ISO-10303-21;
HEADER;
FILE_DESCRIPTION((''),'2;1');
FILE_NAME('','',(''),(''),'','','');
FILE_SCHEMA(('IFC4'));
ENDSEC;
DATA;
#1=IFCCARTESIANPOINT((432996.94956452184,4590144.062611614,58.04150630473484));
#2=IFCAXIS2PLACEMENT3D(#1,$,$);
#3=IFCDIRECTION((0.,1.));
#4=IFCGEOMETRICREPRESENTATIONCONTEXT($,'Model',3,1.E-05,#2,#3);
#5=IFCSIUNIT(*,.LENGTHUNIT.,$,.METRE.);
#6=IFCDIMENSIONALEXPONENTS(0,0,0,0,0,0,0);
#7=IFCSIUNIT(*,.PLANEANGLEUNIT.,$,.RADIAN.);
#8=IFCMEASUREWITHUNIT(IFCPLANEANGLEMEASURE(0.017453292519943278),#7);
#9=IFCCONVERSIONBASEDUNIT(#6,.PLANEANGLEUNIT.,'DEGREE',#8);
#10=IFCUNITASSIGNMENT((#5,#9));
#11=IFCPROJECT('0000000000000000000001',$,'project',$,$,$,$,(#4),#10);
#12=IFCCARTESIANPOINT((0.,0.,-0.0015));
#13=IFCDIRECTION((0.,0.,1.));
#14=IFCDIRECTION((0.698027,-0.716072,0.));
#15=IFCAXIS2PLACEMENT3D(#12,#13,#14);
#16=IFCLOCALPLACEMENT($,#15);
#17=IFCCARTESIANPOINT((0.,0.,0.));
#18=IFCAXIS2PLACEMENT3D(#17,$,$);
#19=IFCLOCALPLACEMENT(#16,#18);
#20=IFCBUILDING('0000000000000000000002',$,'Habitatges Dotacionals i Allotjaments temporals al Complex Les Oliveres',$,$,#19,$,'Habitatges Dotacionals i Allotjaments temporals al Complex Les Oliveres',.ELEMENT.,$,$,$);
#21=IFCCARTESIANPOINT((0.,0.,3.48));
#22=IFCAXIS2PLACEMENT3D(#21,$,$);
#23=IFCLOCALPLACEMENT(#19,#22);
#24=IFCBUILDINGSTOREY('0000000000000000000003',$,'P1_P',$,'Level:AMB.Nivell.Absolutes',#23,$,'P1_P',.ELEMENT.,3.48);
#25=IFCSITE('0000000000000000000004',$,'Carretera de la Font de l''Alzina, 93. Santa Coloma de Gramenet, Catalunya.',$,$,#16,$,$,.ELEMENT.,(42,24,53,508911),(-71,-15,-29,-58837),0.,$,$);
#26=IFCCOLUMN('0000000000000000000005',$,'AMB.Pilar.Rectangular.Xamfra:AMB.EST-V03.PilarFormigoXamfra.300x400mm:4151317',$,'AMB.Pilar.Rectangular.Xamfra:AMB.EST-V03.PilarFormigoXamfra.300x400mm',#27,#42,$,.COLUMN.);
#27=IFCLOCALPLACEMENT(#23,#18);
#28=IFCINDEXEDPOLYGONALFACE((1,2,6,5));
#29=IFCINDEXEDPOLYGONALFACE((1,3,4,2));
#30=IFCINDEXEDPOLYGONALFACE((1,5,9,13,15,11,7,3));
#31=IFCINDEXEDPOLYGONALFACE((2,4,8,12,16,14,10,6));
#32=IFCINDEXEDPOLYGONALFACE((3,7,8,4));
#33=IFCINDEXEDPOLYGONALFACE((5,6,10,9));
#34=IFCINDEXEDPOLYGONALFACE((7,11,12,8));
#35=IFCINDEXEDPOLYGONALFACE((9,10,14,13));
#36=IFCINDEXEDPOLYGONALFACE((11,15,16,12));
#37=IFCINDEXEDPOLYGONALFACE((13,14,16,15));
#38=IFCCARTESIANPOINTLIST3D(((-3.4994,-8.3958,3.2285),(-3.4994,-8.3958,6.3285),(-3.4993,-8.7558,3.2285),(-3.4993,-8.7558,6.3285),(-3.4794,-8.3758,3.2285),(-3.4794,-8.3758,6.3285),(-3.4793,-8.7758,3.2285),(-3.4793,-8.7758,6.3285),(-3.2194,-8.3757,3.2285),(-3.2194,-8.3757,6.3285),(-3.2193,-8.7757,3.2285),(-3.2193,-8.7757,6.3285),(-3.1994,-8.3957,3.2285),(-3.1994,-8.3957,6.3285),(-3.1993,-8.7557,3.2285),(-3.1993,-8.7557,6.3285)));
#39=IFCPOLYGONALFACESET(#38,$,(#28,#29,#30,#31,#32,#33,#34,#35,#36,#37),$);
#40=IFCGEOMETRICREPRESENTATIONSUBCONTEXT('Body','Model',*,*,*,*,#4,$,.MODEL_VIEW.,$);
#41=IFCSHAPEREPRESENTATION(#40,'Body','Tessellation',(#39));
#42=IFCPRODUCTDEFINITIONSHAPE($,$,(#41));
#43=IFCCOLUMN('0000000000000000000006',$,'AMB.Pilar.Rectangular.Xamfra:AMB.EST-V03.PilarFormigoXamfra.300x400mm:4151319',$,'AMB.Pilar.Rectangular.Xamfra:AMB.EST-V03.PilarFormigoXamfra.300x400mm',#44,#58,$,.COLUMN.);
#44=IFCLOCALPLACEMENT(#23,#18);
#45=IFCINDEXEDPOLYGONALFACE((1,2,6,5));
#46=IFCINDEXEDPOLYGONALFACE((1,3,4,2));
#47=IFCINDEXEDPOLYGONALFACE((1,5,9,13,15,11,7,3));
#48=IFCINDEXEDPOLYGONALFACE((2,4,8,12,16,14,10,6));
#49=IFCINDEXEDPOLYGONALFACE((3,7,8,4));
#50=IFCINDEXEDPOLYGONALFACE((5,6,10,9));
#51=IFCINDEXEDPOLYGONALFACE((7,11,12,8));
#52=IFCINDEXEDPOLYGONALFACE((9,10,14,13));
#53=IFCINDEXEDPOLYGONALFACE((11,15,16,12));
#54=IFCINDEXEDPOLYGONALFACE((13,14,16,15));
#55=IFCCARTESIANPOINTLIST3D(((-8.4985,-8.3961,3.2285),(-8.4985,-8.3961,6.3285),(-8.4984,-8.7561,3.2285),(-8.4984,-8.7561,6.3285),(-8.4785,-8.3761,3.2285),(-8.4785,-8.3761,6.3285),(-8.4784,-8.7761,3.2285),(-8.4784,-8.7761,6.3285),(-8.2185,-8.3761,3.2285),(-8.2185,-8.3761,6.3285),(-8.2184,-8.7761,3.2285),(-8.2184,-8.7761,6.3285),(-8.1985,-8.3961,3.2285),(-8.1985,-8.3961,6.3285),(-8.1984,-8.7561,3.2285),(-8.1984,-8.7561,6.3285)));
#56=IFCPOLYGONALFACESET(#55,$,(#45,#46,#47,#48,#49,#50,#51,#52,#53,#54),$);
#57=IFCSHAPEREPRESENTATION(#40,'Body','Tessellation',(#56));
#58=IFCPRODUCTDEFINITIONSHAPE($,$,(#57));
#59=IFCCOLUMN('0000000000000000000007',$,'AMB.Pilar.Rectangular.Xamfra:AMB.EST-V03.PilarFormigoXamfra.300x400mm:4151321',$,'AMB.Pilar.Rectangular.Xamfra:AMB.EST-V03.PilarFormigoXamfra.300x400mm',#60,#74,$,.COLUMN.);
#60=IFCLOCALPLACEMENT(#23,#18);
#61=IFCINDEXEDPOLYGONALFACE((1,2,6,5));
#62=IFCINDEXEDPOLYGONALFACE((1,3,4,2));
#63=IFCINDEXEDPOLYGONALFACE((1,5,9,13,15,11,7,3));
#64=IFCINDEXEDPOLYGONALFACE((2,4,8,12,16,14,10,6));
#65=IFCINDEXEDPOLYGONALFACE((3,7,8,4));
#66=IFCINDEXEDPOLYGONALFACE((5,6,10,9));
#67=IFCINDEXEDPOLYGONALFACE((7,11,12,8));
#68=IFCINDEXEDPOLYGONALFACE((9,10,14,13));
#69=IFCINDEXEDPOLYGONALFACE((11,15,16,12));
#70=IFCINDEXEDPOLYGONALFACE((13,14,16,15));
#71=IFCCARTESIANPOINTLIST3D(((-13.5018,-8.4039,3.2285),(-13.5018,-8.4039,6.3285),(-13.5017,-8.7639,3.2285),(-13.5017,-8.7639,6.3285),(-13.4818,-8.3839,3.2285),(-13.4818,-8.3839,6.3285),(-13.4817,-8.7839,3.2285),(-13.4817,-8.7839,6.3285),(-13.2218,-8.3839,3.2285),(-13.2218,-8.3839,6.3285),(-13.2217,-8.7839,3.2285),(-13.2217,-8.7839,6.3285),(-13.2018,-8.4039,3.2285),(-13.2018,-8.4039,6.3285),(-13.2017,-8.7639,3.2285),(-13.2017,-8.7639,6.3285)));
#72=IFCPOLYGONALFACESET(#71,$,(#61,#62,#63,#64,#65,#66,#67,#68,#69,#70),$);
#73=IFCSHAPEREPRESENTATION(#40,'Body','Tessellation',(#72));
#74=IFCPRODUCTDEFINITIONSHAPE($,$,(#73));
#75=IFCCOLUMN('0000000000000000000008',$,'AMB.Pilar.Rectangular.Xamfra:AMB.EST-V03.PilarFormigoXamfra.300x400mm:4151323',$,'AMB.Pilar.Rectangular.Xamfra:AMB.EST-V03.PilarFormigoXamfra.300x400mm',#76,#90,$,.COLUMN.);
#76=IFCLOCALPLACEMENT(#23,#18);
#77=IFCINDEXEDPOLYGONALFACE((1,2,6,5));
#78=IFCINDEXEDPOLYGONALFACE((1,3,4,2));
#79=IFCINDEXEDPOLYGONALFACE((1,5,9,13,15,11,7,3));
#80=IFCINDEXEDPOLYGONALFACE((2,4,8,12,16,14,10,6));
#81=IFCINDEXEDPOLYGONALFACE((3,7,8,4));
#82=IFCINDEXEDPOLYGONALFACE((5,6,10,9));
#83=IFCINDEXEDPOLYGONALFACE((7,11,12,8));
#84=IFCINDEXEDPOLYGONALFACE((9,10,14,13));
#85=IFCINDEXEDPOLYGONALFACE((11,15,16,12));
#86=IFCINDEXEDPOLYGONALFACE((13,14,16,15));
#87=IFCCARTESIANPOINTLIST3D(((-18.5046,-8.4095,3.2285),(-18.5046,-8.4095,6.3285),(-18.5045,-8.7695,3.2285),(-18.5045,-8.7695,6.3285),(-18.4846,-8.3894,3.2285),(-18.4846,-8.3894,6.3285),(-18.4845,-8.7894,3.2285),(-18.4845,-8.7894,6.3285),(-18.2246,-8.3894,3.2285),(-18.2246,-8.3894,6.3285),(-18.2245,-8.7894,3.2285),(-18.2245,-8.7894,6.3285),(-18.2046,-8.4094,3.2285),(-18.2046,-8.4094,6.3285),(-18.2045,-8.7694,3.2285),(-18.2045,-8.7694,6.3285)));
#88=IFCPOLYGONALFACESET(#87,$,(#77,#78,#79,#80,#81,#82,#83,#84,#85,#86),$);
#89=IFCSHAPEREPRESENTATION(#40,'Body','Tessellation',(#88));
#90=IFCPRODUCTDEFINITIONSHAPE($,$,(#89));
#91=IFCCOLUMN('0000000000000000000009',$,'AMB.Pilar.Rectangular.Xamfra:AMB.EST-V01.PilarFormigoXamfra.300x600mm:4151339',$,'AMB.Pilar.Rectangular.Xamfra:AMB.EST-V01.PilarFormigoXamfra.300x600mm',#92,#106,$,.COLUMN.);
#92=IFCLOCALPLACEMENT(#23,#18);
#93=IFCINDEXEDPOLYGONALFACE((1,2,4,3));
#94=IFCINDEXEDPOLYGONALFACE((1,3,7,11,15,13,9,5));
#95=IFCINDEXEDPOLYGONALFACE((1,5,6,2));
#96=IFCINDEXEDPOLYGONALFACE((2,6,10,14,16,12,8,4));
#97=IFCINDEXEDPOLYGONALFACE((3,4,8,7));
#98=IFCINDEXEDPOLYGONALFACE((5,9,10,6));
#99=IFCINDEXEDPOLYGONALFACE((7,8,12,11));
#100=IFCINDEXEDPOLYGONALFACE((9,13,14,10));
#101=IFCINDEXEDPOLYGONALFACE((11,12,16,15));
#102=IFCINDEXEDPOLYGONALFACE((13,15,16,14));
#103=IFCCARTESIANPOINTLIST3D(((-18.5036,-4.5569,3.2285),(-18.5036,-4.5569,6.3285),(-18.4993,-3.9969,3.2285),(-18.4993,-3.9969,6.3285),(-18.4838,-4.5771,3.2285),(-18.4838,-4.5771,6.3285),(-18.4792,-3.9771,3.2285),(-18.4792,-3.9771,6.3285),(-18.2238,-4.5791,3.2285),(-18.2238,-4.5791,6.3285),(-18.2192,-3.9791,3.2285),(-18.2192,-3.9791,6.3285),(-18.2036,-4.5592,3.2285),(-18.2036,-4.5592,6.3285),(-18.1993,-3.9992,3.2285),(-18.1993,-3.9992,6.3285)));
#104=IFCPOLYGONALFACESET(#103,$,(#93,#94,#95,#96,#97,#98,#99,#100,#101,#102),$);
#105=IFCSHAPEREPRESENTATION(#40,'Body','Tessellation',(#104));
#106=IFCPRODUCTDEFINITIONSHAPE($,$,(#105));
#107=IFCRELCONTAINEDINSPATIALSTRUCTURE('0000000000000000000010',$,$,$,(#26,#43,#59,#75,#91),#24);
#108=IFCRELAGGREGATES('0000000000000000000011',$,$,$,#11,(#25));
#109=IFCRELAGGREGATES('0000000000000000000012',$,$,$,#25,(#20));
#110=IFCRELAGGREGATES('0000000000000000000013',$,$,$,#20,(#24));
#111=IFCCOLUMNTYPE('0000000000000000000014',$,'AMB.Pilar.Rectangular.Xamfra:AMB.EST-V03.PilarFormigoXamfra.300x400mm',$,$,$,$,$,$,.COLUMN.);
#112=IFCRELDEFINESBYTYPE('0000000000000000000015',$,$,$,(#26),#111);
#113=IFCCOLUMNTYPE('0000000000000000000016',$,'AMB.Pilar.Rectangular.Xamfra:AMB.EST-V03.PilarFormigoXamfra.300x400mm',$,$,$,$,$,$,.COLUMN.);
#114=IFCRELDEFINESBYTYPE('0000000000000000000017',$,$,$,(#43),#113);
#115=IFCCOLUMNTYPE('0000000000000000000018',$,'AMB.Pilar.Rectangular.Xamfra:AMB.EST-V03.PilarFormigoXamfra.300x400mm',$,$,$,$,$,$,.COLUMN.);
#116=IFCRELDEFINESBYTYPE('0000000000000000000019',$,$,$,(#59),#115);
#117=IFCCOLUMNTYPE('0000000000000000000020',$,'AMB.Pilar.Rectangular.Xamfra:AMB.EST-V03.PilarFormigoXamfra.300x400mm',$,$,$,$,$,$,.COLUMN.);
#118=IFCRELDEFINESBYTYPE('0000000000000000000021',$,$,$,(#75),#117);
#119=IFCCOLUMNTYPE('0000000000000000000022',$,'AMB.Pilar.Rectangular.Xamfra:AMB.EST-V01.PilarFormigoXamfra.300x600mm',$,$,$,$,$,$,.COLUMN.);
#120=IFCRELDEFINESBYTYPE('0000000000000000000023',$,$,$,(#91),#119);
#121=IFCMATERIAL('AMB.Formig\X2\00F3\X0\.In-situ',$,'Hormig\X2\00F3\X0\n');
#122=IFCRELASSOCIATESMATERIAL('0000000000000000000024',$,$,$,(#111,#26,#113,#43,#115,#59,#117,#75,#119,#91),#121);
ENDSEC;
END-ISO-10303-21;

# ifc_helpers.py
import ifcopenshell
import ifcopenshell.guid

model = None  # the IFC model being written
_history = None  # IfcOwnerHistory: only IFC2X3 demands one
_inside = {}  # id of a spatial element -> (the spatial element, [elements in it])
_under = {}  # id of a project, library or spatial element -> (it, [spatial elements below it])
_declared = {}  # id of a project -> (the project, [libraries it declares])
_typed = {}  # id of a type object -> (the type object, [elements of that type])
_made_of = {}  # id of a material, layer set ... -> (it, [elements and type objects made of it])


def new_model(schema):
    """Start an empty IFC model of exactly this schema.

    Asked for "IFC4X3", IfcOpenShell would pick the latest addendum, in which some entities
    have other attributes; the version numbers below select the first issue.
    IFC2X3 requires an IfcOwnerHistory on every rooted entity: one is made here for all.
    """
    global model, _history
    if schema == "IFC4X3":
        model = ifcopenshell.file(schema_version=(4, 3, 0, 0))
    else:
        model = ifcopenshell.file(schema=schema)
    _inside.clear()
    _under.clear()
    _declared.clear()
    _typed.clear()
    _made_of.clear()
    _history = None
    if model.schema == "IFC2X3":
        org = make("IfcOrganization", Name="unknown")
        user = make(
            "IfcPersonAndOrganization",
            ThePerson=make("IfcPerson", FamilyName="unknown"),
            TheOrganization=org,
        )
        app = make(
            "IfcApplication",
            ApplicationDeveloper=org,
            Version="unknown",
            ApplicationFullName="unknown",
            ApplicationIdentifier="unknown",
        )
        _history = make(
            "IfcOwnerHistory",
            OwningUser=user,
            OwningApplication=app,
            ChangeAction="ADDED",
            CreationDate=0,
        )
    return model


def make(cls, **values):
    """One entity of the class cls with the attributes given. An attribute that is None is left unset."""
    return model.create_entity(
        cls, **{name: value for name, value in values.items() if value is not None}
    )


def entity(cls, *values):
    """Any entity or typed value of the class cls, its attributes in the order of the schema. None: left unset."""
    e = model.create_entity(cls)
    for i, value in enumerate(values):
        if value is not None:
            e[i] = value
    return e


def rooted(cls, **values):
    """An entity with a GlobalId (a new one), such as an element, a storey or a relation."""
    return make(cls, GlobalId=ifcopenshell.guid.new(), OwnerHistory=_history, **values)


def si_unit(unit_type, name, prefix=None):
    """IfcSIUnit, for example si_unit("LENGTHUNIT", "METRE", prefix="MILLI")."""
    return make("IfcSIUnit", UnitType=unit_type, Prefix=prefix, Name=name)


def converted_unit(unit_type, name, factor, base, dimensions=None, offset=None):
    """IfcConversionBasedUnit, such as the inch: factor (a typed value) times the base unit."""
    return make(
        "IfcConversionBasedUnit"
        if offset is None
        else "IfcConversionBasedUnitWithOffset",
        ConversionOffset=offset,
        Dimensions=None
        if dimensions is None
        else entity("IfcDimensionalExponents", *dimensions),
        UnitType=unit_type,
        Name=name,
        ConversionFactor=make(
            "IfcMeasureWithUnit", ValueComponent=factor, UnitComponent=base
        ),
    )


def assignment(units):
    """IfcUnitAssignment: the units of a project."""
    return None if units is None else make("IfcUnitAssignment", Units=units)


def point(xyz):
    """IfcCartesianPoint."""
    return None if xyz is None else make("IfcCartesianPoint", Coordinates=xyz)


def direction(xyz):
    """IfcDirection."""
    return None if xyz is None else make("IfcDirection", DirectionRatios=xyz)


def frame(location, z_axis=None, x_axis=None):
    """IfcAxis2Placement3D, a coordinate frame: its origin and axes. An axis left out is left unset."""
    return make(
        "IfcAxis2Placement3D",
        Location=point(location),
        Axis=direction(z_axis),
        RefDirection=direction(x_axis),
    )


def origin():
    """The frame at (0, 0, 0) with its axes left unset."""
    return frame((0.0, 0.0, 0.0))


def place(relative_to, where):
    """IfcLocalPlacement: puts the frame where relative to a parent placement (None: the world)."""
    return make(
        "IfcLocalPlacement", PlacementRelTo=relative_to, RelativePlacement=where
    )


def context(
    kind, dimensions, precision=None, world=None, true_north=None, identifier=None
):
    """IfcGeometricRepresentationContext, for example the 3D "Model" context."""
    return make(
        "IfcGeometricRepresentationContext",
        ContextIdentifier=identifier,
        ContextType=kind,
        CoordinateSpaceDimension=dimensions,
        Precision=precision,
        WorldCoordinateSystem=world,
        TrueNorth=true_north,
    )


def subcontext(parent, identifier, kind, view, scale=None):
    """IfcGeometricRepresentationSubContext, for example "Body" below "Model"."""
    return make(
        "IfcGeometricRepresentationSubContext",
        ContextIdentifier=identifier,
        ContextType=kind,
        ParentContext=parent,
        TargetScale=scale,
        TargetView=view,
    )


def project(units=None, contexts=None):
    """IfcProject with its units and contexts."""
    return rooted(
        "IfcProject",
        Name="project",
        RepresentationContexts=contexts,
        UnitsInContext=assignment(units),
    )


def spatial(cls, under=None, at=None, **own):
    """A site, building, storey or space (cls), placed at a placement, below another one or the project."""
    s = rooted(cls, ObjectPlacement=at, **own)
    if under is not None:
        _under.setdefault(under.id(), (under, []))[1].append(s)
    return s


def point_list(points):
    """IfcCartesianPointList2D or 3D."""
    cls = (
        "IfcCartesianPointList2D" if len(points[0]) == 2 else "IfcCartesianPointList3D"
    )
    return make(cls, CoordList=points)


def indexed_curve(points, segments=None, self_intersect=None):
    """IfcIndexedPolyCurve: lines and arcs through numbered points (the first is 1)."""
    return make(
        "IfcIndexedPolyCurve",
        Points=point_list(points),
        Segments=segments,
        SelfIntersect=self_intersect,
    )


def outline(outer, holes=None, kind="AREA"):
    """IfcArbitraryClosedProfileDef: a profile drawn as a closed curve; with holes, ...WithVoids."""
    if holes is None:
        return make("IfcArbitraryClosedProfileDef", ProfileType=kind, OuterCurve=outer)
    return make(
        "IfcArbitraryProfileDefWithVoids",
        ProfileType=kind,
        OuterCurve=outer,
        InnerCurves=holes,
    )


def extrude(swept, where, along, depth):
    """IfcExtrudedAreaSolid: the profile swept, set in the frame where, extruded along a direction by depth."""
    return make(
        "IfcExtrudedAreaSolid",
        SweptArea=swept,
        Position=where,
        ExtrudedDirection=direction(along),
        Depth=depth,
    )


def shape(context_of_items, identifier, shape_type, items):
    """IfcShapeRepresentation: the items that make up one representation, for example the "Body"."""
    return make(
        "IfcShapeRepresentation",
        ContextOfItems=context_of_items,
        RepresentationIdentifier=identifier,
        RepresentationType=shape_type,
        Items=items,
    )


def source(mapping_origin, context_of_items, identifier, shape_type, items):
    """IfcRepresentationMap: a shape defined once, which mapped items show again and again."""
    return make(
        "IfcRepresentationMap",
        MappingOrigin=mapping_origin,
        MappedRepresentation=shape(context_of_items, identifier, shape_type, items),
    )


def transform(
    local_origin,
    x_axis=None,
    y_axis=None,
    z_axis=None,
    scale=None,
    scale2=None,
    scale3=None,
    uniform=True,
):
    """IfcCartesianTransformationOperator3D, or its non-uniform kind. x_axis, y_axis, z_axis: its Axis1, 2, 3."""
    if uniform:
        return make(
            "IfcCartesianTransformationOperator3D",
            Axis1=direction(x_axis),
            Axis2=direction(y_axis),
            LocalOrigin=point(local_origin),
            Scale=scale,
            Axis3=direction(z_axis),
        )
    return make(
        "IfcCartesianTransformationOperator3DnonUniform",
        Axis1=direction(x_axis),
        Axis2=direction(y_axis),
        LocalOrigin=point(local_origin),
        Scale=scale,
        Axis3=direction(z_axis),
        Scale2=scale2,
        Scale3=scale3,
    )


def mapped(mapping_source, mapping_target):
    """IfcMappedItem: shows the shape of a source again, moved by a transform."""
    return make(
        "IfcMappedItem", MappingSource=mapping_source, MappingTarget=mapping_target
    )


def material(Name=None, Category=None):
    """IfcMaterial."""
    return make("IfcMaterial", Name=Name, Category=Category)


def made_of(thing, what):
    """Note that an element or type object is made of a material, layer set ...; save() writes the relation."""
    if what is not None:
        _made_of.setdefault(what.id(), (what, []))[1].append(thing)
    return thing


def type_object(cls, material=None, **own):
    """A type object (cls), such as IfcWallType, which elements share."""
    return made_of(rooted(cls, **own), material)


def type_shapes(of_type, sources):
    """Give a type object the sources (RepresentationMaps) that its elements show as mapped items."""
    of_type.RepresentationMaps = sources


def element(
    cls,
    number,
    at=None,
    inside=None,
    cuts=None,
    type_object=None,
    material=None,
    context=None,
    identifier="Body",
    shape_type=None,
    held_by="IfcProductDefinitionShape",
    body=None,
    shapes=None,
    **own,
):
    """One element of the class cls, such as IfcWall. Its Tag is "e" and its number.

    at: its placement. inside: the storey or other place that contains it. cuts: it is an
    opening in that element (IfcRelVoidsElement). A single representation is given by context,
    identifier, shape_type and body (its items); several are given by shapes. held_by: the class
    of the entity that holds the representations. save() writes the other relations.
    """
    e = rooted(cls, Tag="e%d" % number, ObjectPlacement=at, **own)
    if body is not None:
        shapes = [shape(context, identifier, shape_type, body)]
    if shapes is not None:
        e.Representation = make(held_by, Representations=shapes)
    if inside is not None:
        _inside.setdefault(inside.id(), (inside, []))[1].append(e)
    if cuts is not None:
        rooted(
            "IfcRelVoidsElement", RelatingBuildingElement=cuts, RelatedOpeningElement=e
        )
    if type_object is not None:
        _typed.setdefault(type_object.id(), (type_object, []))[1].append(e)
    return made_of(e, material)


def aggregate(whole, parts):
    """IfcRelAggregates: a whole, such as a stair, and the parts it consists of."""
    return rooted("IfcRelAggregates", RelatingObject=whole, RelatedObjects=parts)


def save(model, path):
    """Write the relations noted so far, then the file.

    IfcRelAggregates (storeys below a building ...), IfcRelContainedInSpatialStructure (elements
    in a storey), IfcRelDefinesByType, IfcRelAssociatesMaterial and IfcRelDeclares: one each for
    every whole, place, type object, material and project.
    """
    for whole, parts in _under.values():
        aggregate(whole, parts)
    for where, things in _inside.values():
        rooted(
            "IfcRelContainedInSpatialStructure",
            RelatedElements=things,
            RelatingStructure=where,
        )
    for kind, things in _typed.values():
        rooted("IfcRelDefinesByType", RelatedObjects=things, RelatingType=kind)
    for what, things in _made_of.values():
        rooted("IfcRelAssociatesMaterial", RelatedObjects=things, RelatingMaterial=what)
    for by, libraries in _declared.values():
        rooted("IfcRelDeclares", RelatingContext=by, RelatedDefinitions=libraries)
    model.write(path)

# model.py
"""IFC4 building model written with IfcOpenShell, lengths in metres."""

from ifc_helpers import new_model, entity, si_unit, converted_unit, direction, frame, origin, place, context, subcontext, project, spatial, indexed_curve, outline, extrude, source, transform, mapped, material, type_object, type_shapes, element, save


model = new_model("IFC4")

# Units and contexts
model_context = context("Model", 3, precision=1e-05, world=frame((432996.94956452184, 4590144.062611614, 58.04150630473484)), true_north=direction((0.0, 1.0)))
body_context = subcontext(model_context, "Body", "Model", "MODEL_VIEW")
ifc_project = project(units=[si_unit("LENGTHUNIT", "METRE"), converted_unit("PLANEANGLEUNIT", "DEGREE", entity("IfcPlaneAngleMeasure", 0.017453292519943278), si_unit("PLANEANGLEUNIT", "RADIAN"), dimensions=[0, 0, 0, 0, 0, 0, 0])], contexts=[model_context])

# Site, building, storey
site_placement = place(None, frame((0.0, 0.0, -0.0015), z_axis=(0.0, 0.0, 1.0), x_axis=(0.698027, -0.716072, 0.0)))
site = spatial("IfcSite", under=ifc_project, at=site_placement, Name="Carretera de la Font de l'Alzina, 93. Santa Coloma de Gramenet, Catalunya.", CompositionType="ELEMENT", RefLatitude=(42, 24, 53, 508911), RefLongitude=(-71, -15, -29, -58837), RefElevation=0.0)
building_placement = place(site_placement, origin())
building = spatial("IfcBuilding", under=site, at=building_placement, Name="Habitatges Dotacionals i Allotjaments temporals al Complex Les Oliveres", LongName="Habitatges Dotacionals i Allotjaments temporals al Complex Les Oliveres", CompositionType="ELEMENT")
storey_placement = place(building_placement, frame((0.0, 0.0, 3.48)))
storey = spatial("IfcBuildingStorey", under=building, at=storey_placement, Name="P1_P", ObjectType="Level:AMB.Nivell.Absolutes", LongName="P1_P", CompositionType="ELEMENT", Elevation=3.48)

# Columns
ifc_material = material(Name="AMB.Formigó.In-situ", Category="Hormigón")
column_type_1 = type_object("IfcColumnType", Name="AMB.Pilar.Rectangular.Xamfra:AMB.EST-V03.PilarFormigoXamfra.300x400mm", PredefinedType="COLUMN", material=ifc_material)
shared_shape_1 = source(origin(), body_context, "Body", "SweptSolid", [
    extrude(outline(indexed_curve([(-0.13, -0.2), (0.13, -0.2), (0.15, -0.18), (0.15, 0.18), (0.13, 0.2), (-0.13, 0.2), (-0.15, 0.18), (-0.15, -0.18), (-0.13, -0.2)], self_intersect=False)), frame((-3.3493, -8.5757, 6.7085), z_axis=(0.0, 0.0, 1.0), x_axis=(1.0, 0.000195, 0.0)), (0.0, 0.0, 1.0), 3.1),
])
type_shapes(column_type_1, [shared_shape_1])
column_1_placement = place(storey_placement, frame((0.0, 0.0, -3.48)))
element("IfcColumn", 1, at=column_1_placement, inside=storey, type_object=column_type_1, material=ifc_material, Name="AMB.Pilar.Rectangular.Xamfra:AMB.EST-V03.PilarFormigoXamfra.300x400mm:4151317", ObjectType="AMB.Pilar.Rectangular.Xamfra:AMB.EST-V03.PilarFormigoXamfra.300x400mm", PredefinedType="COLUMN", context=body_context, shape_type="MappedRepresentation", body=[
    mapped(shared_shape_1, transform((0.0, 0.0, 0.0), scale=1.0)),
])
column_type_2 = type_object("IfcColumnType", Name="AMB.Pilar.Rectangular.Xamfra:AMB.EST-V03.PilarFormigoXamfra.300x400mm", PredefinedType="COLUMN", material=ifc_material)
shared_shape_2 = source(origin(), body_context, "Body", "SweptSolid", [
    extrude(outline(indexed_curve([(-0.13, -0.2), (0.13, -0.2), (0.15, -0.18), (0.15, 0.18), (0.13, 0.2), (-0.13, 0.2), (-0.15, 0.18), (-0.15, -0.18), (-0.13, -0.2)], self_intersect=False)), frame((-8.3484, -8.5761, 6.7085), z_axis=(0.0, 0.0, 1.0), x_axis=(1.0, 0.000195, 0.0)), (0.0, 0.0, 1.0), 3.1),
])
type_shapes(column_type_2, [shared_shape_2])
column_2_placement = place(storey_placement, frame((0.0, 0.0, -3.48)))
element("IfcColumn", 2, at=column_2_placement, inside=storey, type_object=column_type_2, material=ifc_material, Name="AMB.Pilar.Rectangular.Xamfra:AMB.EST-V03.PilarFormigoXamfra.300x400mm:4151319", ObjectType="AMB.Pilar.Rectangular.Xamfra:AMB.EST-V03.PilarFormigoXamfra.300x400mm", PredefinedType="COLUMN", context=body_context, shape_type="MappedRepresentation", body=[
    mapped(shared_shape_2, transform((0.0, 0.0, 0.0), scale=1.0)),
])
column_type_3 = type_object("IfcColumnType", Name="AMB.Pilar.Rectangular.Xamfra:AMB.EST-V03.PilarFormigoXamfra.300x400mm", PredefinedType="COLUMN", material=ifc_material)
shared_shape_3 = source(origin(), body_context, "Body", "SweptSolid", [
    extrude(outline(indexed_curve([(-0.13, -0.2), (0.13, -0.2), (0.15, -0.18), (0.15, 0.18), (0.13, 0.2), (-0.13, 0.2), (-0.15, 0.18), (-0.15, -0.18), (-0.13, -0.2)], self_intersect=False)), frame((-13.3518, -8.5839, 6.7085), z_axis=(0.0, 0.0, 1.0), x_axis=(1.0, 0.000195, 0.0)), (0.0, 0.0, 1.0), 3.1),
])
type_shapes(column_type_3, [shared_shape_3])
column_3_placement = place(storey_placement, frame((0.0, 0.0, -3.48)))
element("IfcColumn", 3, at=column_3_placement, inside=storey, type_object=column_type_3, material=ifc_material, Name="AMB.Pilar.Rectangular.Xamfra:AMB.EST-V03.PilarFormigoXamfra.300x400mm:4151321", ObjectType="AMB.Pilar.Rectangular.Xamfra:AMB.EST-V03.PilarFormigoXamfra.300x400mm", PredefinedType="COLUMN", context=body_context, shape_type="MappedRepresentation", body=[
    mapped(shared_shape_3, transform((0.0, 0.0, 0.0), scale=1.0)),
])
column_type_4 = type_object("IfcColumnType", Name="AMB.Pilar.Rectangular.Xamfra:AMB.EST-V03.PilarFormigoXamfra.300x400mm", PredefinedType="COLUMN", material=ifc_material)
shared_shape_4 = source(origin(), body_context, "Body", "SweptSolid", [
    extrude(outline(indexed_curve([(-0.13, -0.2), (0.13, -0.2), (0.15, -0.18), (0.15, 0.18), (0.13, 0.2), (-0.13, 0.2), (-0.15, 0.18), (-0.15, -0.18), (-0.13, -0.2)], self_intersect=False)), frame((-18.3546, -8.5894, 6.7085), z_axis=(0.0, 0.0, 1.0), x_axis=(1.0, 0.000195, 0.0)), (0.0, 0.0, 1.0), 3.1),
])
type_shapes(column_type_4, [shared_shape_4])
column_4_placement = place(storey_placement, frame((0.0, 0.0, -3.48)))
element("IfcColumn", 4, at=column_4_placement, inside=storey, type_object=column_type_4, material=ifc_material, Name="AMB.Pilar.Rectangular.Xamfra:AMB.EST-V03.PilarFormigoXamfra.300x400mm:4151323", ObjectType="AMB.Pilar.Rectangular.Xamfra:AMB.EST-V03.PilarFormigoXamfra.300x400mm", PredefinedType="COLUMN", context=body_context, shape_type="MappedRepresentation", body=[
    mapped(shared_shape_4, transform((0.0, 0.0, 0.0), scale=1.0)),
])
column_type_5 = type_object("IfcColumnType", Name="AMB.Pilar.Rectangular.Xamfra:AMB.EST-V01.PilarFormigoXamfra.300x600mm", PredefinedType="COLUMN", material=ifc_material)
shared_shape_5 = source(origin(), body_context, "Body", "SweptSolid", [
    extrude(outline(indexed_curve([(-0.13, -0.3), (0.13, -0.3), (0.15, -0.28), (0.15, 0.28), (0.13, 0.3), (-0.13, 0.3), (-0.15, 0.28), (-0.15, -0.28), (-0.13, -0.3)], self_intersect=False)), frame((-18.3515, -4.2781, 6.7085), z_axis=(0.0, 0.0, 1.0), x_axis=(0.999971, -0.007654, 0.0)), (0.0, 0.0, 1.0), 3.1),
])
type_shapes(column_type_5, [shared_shape_5])
column_5_placement = place(storey_placement, frame((0.0, 0.0, -3.48)))
element("IfcColumn", 5, at=column_5_placement, inside=storey, type_object=column_type_5, material=ifc_material, Name="AMB.Pilar.Rectangular.Xamfra:AMB.EST-V01.PilarFormigoXamfra.300x600mm:4151339", ObjectType="AMB.Pilar.Rectangular.Xamfra:AMB.EST-V01.PilarFormigoXamfra.300x600mm", PredefinedType="COLUMN", context=body_context, shape_type="MappedRepresentation", body=[
    mapped(shared_shape_5, transform((0.0, 0.0, 0.0), scale=1.0)),
])

save(model, "model.ifc")
